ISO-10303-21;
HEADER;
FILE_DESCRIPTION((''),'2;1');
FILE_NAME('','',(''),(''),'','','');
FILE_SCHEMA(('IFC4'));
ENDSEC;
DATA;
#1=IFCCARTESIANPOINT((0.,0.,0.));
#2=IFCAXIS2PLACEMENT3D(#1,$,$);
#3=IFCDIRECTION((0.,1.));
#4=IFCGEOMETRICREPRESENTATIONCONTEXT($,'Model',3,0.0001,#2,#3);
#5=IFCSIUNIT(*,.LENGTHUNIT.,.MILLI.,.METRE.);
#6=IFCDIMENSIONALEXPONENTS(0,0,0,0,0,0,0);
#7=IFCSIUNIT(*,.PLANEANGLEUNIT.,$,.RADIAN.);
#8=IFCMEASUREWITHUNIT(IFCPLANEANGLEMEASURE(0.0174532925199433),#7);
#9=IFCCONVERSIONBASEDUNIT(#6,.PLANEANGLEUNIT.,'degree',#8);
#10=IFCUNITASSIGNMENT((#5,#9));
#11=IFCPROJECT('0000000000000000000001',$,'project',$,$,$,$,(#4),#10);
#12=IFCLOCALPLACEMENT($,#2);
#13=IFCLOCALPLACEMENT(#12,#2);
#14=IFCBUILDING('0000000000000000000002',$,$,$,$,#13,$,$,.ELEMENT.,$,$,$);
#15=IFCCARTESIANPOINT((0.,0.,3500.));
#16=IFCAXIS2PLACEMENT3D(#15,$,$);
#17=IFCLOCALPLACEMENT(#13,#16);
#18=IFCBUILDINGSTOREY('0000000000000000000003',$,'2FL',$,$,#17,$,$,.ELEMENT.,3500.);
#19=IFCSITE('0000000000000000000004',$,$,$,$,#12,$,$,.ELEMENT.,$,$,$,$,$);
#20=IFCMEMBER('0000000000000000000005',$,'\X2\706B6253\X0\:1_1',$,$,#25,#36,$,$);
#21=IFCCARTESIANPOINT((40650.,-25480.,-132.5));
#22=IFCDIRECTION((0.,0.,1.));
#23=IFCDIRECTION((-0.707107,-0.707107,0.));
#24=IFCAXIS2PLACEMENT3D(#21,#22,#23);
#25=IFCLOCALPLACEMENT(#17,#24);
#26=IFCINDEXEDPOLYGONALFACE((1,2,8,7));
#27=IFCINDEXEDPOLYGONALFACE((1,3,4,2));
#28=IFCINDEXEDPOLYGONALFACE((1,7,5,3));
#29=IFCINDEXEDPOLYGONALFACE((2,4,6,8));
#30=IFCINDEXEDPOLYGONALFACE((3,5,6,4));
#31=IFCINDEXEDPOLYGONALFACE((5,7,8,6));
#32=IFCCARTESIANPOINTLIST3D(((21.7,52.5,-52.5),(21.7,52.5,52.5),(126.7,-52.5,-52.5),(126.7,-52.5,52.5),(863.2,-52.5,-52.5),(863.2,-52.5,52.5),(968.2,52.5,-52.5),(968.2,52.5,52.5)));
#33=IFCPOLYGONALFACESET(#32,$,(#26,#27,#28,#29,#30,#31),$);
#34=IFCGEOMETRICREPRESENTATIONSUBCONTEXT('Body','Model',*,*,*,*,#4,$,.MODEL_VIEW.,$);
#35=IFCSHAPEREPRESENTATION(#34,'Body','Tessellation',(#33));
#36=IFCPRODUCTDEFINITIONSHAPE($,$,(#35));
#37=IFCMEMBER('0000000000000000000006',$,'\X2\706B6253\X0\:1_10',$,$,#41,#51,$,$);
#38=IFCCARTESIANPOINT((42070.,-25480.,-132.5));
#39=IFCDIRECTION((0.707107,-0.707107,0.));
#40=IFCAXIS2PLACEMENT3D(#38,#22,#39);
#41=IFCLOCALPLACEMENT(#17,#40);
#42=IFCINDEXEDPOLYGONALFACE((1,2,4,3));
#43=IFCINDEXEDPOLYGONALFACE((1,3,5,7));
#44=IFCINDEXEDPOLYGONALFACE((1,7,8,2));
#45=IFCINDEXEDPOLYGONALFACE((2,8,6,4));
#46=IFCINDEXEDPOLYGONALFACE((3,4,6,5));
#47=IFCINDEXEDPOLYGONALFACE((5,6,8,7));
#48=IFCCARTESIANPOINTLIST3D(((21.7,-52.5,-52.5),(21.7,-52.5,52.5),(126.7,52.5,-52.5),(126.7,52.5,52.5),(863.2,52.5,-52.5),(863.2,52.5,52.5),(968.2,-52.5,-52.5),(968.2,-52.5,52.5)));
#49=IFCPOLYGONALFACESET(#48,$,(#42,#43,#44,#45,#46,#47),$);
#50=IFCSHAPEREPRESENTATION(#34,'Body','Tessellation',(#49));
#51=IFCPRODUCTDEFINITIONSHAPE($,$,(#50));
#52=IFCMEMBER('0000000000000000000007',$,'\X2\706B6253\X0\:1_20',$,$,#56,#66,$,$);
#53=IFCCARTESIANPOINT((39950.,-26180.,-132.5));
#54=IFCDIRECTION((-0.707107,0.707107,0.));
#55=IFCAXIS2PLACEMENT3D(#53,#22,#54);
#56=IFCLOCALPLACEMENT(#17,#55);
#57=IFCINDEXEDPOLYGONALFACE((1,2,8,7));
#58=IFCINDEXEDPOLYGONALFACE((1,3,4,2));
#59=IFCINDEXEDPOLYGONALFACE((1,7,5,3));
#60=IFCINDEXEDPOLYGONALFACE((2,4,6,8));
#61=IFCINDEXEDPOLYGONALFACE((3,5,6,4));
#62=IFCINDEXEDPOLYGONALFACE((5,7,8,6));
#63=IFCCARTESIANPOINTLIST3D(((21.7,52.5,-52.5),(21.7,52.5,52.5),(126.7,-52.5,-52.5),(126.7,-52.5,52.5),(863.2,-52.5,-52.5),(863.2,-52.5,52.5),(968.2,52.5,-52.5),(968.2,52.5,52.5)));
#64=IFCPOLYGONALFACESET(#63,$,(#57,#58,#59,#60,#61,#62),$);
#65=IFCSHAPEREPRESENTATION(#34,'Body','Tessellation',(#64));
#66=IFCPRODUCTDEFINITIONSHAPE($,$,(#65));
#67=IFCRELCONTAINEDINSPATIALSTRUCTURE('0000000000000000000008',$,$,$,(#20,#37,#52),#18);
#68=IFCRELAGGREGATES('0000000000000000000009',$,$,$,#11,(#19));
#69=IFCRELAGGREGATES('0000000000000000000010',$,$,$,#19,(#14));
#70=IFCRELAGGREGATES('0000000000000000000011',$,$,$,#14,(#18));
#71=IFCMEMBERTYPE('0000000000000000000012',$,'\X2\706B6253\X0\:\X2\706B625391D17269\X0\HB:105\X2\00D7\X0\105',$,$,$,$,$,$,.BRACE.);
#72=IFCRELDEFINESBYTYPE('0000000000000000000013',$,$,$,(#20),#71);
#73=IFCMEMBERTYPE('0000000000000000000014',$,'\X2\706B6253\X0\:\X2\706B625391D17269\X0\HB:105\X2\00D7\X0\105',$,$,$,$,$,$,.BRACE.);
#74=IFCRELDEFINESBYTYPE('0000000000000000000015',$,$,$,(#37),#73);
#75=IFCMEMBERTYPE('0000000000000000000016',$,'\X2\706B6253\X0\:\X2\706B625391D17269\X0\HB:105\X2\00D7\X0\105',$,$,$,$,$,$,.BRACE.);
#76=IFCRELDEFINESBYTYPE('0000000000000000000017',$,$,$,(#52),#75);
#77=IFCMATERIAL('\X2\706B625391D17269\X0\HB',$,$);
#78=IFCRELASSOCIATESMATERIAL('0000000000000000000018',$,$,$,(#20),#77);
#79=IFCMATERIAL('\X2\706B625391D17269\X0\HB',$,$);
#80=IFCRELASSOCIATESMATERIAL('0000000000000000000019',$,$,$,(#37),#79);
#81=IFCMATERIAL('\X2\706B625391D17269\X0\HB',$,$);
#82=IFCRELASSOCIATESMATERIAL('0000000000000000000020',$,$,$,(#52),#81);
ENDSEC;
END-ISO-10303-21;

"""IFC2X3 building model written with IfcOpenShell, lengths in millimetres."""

from ifc_helpers import new_model, entity, si_unit, converted_unit, direction, frame, origin, place, context, subcontext, project, spatial, polyline, outline, extrude, material, type_object, element, save


model = new_model("IFC2X3")

# Units and contexts
model_context = context("Model", 3, precision=0.0001, world=origin(), true_north=direction((0.0, 1.0)))
body_context = subcontext(model_context, "Body", "Model", "MODEL_VIEW")
ifc_project = project(units=[si_unit("LENGTHUNIT", "METRE", prefix="MILLI"), converted_unit("PLANEANGLEUNIT", "degree", entity("IfcPlaneAngleMeasure", 0.0174532925199433), si_unit("PLANEANGLEUNIT", "RADIAN"), dimensions=[0, 0, 0, 0, 0, 0, 0])], contexts=[model_context])

# Site, building, storey
site_placement = place(None, origin())
site = spatial("IfcSite", under=ifc_project, at=site_placement, CompositionType="ELEMENT")
building_placement = place(site_placement, origin())
building = spatial("IfcBuilding", under=site, at=building_placement, CompositionType="ELEMENT")
storey_placement = place(building_placement, frame((0.0, 0.0, 3500.0)))
storey = spatial("IfcBuildingStorey", under=building, at=storey_placement, Name="2FL", CompositionType="ELEMENT", Elevation=3500.0)

# Members
ifc_material_1 = material(Name="火打金物HB")
member_type_1 = type_object("IfcMemberType", Name="火打:火打金物HB:105×105", PredefinedType="BRACE")
member_1_placement = place(storey_placement, frame((40650.0, -25480.0, -132.5), z_axis=(0.0, 0.0, 1.0), x_axis=(-0.707107, -0.707107, 0.0)))
element("IfcMember", 1, at=member_1_placement, inside=storey, type_object=member_type_1, material=ifc_material_1, Name="火打:1_1", context=body_context, shape_type="SweptSolid", body=[
    extrude(outline(polyline([(126.7, -52.5, 0.0), (21.7, 52.5, 0.0), (968.2, 52.5, 0.0), (863.2, -52.5, 0.0), (126.7, -52.5, 0.0)])), frame((0.0, 0.0, -52.5), z_axis=(0.0, 0.0, 1.0), x_axis=(1.0, 0.0, 0.0)), (0.0, 0.0, 1.0), 105.0),
])
ifc_material_2 = material(Name="火打金物HB")
member_type_2 = type_object("IfcMemberType", Name="火打:火打金物HB:105×105", PredefinedType="BRACE")
member_2_placement = place(storey_placement, frame((42070.0, -25480.0, -132.5), z_axis=(0.0, 0.0, 1.0), x_axis=(0.707107, -0.707107, 0.0)))
element("IfcMember", 2, at=member_2_placement, inside=storey, type_object=member_type_2, material=ifc_material_2, Name="火打:1_10", context=body_context, shape_type="SweptSolid", body=[
    extrude(outline(polyline([(21.7, -52.5, 0.0), (126.7, 52.5, 0.0), (863.2, 52.5, 0.0), (968.2, -52.5, 0.0), (21.7, -52.5, 0.0)])), frame((0.0, 0.0, -52.5), z_axis=(0.0, 0.0, 1.0), x_axis=(1.0, 0.0, 0.0)), (0.0, 0.0, 1.0), 105.0),
])
ifc_material_3 = material(Name="火打金物HB")
member_type_3 = type_object("IfcMemberType", Name="火打:火打金物HB:105×105", PredefinedType="BRACE")
member_3_placement = place(storey_placement, frame((39950.0, -26180.0, -132.5), z_axis=(0.0, 0.0, 1.0), x_axis=(-0.707107, 0.707107, 0.0)))
element("IfcMember", 3, at=member_3_placement, inside=storey, type_object=member_type_3, material=ifc_material_3, Name="火打:1_20", context=body_context, shape_type="SweptSolid", body=[
    extrude(outline(polyline([(126.7, -52.5, 0.0), (21.7, 52.5, 0.0), (968.2, 52.5, 0.0), (863.2, -52.5, 0.0), (126.7, -52.5, 0.0)])), frame((0.0, 0.0, -52.5), z_axis=(0.0, 0.0, 1.0), x_axis=(1.0, 0.0, 0.0)), (0.0, 0.0, 1.0), 105.0),
])

save(model, "model.ifc")
